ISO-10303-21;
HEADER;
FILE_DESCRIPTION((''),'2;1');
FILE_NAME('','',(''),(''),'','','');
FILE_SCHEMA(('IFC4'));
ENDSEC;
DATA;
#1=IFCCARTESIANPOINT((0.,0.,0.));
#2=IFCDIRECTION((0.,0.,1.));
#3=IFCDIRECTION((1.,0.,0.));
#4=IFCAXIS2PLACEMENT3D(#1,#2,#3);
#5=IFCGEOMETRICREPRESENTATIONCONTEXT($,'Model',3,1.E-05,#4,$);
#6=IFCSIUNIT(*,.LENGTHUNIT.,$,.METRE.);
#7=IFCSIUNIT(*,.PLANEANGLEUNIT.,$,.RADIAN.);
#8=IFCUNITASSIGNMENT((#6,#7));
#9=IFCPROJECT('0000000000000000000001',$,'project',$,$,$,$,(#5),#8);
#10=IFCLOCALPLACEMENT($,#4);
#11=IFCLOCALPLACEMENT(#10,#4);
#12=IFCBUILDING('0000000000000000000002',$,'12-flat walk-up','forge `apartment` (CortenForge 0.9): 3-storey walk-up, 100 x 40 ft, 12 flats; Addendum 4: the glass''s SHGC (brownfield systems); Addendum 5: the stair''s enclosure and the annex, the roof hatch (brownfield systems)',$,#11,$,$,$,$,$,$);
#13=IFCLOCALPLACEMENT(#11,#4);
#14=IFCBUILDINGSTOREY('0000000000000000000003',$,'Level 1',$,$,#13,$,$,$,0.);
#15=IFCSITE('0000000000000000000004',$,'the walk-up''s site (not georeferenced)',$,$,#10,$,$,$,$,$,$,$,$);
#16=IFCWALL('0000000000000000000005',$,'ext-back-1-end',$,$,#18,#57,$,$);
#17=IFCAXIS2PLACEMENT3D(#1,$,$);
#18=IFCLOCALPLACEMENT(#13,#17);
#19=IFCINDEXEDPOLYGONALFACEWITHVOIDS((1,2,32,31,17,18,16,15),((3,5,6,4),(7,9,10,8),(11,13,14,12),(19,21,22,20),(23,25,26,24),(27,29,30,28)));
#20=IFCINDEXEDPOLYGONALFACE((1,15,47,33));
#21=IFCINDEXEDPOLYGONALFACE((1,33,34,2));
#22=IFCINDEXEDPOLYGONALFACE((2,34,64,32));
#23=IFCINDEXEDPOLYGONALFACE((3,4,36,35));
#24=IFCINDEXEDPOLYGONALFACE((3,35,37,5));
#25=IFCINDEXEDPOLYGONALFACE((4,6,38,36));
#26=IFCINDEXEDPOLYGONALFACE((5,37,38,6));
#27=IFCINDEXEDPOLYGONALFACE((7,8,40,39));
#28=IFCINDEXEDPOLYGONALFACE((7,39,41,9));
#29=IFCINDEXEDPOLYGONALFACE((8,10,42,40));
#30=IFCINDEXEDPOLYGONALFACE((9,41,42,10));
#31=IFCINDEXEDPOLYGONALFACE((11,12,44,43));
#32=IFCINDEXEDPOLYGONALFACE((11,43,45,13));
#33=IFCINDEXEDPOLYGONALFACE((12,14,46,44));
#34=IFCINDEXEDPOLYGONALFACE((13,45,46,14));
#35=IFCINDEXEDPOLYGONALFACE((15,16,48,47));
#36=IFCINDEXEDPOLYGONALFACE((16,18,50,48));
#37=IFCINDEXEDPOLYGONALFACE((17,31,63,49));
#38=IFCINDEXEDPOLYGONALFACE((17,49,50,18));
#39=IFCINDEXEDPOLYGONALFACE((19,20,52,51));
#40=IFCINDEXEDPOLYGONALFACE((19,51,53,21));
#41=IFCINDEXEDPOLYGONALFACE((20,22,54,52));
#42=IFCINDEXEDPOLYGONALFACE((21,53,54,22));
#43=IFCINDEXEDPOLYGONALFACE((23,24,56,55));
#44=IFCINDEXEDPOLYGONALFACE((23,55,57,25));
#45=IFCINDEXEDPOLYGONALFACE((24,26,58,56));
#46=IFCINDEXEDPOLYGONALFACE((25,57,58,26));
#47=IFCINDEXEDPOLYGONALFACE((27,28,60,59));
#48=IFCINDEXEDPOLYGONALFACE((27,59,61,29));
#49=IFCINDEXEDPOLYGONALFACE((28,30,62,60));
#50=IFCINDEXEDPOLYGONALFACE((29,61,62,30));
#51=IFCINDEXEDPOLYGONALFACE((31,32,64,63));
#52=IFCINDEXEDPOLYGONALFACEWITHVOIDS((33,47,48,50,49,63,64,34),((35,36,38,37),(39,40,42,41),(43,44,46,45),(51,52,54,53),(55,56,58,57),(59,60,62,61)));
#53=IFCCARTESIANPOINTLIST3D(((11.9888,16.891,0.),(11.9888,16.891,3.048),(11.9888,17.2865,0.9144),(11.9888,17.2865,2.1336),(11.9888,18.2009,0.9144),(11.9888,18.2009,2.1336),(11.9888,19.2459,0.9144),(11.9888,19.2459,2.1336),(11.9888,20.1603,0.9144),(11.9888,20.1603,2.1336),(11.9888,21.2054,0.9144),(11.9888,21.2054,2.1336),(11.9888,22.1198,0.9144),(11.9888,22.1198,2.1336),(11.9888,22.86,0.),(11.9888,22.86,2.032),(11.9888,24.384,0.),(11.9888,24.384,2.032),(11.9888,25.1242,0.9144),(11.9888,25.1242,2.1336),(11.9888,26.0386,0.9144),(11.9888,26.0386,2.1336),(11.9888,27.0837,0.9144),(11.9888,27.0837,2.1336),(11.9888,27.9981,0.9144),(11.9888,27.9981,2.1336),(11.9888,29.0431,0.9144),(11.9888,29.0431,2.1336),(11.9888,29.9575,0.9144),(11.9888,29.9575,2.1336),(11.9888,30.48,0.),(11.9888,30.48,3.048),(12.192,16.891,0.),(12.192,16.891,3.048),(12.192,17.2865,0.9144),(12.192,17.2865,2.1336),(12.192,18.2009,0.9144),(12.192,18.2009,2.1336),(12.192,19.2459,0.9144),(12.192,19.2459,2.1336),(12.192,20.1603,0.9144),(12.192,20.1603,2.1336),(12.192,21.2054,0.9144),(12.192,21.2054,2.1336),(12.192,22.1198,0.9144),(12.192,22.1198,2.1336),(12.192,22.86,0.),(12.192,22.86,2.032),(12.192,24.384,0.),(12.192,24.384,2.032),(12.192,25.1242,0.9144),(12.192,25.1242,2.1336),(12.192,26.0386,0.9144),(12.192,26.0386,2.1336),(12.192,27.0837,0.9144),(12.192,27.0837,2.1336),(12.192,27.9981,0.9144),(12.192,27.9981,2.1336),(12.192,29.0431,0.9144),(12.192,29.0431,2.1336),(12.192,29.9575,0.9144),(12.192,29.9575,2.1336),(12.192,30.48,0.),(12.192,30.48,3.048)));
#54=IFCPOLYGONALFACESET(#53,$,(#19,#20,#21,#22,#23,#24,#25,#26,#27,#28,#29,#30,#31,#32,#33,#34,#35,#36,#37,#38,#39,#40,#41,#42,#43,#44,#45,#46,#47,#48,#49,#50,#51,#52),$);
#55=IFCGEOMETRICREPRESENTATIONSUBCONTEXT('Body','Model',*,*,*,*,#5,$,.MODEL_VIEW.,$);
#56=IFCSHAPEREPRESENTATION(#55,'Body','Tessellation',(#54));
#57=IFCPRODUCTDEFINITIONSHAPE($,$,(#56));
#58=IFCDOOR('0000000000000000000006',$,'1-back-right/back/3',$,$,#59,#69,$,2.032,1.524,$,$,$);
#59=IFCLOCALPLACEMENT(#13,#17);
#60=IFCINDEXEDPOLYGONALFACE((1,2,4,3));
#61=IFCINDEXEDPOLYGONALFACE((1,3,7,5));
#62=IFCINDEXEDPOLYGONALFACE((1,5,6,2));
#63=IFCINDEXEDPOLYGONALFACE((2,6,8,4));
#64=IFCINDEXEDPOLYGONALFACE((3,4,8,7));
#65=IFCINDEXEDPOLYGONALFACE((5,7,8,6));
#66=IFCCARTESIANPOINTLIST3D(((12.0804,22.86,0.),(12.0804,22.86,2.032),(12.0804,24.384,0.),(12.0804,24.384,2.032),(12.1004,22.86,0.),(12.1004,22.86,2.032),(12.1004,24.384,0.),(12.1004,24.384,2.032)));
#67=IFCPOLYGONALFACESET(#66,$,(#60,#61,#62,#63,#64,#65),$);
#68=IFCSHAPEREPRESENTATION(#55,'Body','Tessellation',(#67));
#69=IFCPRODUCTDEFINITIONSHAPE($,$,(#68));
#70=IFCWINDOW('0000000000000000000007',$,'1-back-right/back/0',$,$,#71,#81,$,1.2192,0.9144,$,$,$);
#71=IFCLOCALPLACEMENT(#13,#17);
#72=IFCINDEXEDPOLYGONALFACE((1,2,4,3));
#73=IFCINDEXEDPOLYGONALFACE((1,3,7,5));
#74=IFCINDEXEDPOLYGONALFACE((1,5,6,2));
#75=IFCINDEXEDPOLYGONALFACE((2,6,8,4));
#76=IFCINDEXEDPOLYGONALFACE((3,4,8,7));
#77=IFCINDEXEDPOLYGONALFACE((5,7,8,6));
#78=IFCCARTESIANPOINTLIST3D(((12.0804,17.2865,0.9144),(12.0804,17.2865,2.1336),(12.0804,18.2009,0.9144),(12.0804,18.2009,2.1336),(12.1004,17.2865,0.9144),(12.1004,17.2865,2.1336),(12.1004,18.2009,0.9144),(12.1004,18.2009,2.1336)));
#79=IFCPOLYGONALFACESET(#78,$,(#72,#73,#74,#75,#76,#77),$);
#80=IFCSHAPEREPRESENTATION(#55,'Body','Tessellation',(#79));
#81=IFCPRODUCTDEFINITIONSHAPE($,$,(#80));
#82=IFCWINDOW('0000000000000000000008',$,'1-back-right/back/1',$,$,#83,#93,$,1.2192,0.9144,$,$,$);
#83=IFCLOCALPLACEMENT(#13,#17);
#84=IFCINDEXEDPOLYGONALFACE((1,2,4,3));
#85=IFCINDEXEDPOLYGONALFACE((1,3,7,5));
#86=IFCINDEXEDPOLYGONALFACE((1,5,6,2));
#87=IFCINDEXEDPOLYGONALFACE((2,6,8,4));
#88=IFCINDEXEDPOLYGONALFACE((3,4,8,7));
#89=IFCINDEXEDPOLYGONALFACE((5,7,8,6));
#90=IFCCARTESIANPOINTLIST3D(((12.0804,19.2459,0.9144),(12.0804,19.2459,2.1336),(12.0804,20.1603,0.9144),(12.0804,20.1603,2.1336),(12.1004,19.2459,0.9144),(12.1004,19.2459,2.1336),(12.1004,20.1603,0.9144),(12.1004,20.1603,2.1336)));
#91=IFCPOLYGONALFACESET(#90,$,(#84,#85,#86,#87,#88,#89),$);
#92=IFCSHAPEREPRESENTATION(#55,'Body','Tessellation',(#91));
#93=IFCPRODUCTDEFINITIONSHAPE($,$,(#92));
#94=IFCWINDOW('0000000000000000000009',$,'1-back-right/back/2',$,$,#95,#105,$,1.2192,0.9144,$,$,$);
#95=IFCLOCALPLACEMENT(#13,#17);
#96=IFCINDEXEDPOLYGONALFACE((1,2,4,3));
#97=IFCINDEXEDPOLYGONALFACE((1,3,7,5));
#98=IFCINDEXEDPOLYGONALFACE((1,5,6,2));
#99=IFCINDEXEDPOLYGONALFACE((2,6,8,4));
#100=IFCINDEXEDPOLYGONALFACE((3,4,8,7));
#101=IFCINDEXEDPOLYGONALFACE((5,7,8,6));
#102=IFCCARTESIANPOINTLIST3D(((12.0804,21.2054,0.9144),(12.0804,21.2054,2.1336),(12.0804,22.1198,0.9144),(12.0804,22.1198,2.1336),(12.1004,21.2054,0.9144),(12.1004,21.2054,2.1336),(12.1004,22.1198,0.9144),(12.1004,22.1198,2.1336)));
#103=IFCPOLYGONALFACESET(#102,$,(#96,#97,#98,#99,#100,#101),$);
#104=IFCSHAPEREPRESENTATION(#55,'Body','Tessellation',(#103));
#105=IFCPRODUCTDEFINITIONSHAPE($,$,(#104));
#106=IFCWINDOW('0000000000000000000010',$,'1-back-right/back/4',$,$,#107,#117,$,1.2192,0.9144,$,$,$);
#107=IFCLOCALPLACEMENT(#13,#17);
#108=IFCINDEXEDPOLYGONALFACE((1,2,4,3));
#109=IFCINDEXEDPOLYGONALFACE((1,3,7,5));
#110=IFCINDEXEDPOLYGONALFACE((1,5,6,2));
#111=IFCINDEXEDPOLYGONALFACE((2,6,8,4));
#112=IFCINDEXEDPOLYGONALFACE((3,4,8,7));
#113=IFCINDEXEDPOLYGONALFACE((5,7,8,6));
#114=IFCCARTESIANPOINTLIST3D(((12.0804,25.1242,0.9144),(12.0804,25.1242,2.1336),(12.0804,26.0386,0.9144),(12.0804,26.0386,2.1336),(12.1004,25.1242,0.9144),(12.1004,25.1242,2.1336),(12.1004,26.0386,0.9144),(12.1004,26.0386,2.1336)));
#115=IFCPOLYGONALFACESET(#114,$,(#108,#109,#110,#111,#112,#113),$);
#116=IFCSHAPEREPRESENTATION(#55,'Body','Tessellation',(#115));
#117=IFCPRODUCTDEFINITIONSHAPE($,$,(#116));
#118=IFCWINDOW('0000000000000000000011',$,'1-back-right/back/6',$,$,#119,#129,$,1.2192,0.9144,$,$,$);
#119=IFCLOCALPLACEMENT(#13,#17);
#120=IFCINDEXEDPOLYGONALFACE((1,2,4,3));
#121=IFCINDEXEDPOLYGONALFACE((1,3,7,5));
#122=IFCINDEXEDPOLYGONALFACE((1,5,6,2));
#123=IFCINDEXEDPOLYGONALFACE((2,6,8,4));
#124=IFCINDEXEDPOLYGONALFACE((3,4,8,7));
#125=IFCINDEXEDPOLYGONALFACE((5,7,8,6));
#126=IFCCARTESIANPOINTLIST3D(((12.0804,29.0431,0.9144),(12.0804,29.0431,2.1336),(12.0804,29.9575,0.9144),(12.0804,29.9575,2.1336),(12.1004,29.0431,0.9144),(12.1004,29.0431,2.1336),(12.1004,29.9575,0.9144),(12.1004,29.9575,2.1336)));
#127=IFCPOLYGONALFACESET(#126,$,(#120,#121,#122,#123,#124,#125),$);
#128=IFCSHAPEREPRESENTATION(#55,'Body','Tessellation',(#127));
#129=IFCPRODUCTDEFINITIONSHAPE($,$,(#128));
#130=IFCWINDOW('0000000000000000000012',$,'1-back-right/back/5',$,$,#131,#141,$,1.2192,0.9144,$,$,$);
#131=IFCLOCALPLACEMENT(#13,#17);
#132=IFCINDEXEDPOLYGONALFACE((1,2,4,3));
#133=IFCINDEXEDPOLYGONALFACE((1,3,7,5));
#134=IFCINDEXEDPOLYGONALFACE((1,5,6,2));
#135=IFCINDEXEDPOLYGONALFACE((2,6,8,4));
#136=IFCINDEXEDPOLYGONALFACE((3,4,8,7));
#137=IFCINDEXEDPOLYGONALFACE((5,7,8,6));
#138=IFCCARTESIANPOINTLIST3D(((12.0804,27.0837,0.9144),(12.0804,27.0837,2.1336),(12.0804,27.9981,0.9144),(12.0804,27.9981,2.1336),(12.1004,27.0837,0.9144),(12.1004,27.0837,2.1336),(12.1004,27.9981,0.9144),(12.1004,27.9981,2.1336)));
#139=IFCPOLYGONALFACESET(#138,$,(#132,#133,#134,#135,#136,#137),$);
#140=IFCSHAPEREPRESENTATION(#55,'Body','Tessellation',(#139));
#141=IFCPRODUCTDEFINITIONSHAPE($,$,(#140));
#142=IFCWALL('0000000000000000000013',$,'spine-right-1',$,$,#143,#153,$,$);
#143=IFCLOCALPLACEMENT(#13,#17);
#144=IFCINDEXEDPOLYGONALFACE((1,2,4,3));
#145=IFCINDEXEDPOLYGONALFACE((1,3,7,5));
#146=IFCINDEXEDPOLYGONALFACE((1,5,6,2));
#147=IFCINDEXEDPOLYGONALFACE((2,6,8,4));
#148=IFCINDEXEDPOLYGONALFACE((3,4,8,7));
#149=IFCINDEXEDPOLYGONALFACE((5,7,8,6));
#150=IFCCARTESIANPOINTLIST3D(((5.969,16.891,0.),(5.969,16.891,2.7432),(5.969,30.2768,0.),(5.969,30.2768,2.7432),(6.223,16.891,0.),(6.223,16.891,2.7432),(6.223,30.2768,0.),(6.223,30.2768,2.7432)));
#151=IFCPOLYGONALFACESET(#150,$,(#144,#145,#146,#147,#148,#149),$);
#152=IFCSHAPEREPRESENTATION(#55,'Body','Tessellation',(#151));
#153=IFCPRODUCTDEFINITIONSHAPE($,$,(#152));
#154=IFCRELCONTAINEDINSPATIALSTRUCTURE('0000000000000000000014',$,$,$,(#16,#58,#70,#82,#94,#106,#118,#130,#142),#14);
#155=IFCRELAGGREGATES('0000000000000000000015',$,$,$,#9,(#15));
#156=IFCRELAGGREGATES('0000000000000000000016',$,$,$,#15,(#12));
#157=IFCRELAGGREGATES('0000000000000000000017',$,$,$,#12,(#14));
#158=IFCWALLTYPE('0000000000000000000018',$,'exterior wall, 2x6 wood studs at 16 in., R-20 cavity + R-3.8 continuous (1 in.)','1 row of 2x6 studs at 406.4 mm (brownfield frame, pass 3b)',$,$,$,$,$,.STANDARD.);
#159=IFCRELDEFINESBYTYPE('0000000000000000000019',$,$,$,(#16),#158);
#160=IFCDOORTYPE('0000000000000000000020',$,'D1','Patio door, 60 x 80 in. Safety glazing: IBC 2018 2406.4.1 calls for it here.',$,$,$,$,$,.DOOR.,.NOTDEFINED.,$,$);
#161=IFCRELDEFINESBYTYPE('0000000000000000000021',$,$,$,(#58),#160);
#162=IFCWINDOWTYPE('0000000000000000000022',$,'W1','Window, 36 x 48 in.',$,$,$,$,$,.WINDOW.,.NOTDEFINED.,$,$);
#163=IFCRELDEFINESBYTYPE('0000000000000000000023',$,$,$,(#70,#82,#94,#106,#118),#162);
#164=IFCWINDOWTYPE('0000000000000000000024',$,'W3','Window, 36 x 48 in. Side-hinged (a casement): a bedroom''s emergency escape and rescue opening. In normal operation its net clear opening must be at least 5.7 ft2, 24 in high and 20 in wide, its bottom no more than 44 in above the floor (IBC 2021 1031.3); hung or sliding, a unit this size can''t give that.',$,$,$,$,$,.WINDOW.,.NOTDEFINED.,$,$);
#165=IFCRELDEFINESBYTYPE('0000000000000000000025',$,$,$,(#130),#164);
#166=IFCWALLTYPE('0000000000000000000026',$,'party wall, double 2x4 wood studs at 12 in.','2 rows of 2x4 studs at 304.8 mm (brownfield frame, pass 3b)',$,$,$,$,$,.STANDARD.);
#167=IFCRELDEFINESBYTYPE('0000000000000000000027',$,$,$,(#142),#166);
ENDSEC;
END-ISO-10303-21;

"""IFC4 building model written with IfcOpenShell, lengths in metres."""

from ifc_helpers import new_model, si_unit, frame, frame_2d, origin, origin_with_axes, place, context, subcontext, project, spatial, rectangle, extrude, type_object, element, fill, save


model = new_model("IFC4")

# Units and contexts
model_context = context("Model", 3, precision=1e-05, world=origin_with_axes())
body_context = subcontext(model_context, "Body", "Model", "MODEL_VIEW")
ifc_project = project(units=[si_unit("LENGTHUNIT", "METRE"), si_unit("PLANEANGLEUNIT", "RADIAN")], contexts=[model_context])

# Site, building, storey
site_placement = place(None, origin_with_axes())
site = spatial("IfcSite", under=ifc_project, at=site_placement, Name="the walk-up's site (not georeferenced)")
building_placement = place(site_placement, origin_with_axes())
building = spatial("IfcBuilding", under=site, at=building_placement, Name="12-flat walk-up", Description="forge `apartment` (CortenForge 0.9): 3-storey walk-up, 100 x 40 ft, 12 flats; Addendum 4: the glass's SHGC (brownfield systems); Addendum 5: the stair's enclosure and the annex, the roof hatch (brownfield systems)")
storey_placement = place(building_placement, origin_with_axes())
storey = spatial("IfcBuildingStorey", under=building, at=storey_placement, Name="Level 1", Elevation=0.0)

# Wall, openings, door, windows
wall_type_1 = type_object("IfcWallType", Name="exterior wall, 2x6 wood studs at 16 in., R-20 cavity + R-3.8 continuous (1 in.)", Description="1 row of 2x6 studs at 406.4 mm (brownfield frame, pass 3b)", PredefinedType="STANDARD")
wall_1_placement = place(storey_placement, frame((11.9888, 16.891, 0.0), z_axis=(0.0, 0.0, 1.0), x_axis=(1.0, 0.0, 0.0)))
wall_1 = element("IfcWall", 1, at=wall_1_placement, inside=storey, type_object=wall_type_1, Name="ext-back-1-end", context=body_context, shape_type="SweptSolid", body=[
    extrude(rectangle(XDim=0.2032, YDim=13.589, at=frame_2d((0.1016, 6.7945))), origin(), (0.0, 0.0, 1.0), 3.048),
])
opening_1_placement = place(wall_1_placement, frame((0.2032, 0.3955, 0.9144), z_axis=(0.0, 0.0, 1.0), x_axis=(0.0, 1.0, 0.0)))
opening_1 = element("IfcOpeningElement", 2, at=opening_1_placement, cuts=wall_1, PredefinedType="OPENING", context=body_context, shape_type="SweptSolid", body=[
    extrude(rectangle(XDim=0.9144, YDim=0.2032, at=frame_2d((0.4572, 0.1016))), origin(), (0.0, 0.0, 1.0), 1.2192),
])
opening_2_placement = place(wall_1_placement, frame((0.2032, 2.3549, 0.9144), z_axis=(0.0, 0.0, 1.0), x_axis=(0.0, 1.0, 0.0)))
opening_2 = element("IfcOpeningElement", 3, at=opening_2_placement, cuts=wall_1, PredefinedType="OPENING", context=body_context, shape_type="SweptSolid", body=[
    extrude(rectangle(XDim=0.9144, YDim=0.2032, at=frame_2d((0.4572, 0.1016))), origin(), (0.0, 0.0, 1.0), 1.2192),
])
opening_3_placement = place(wall_1_placement, frame((0.2032, 4.3144, 0.9144), z_axis=(0.0, 0.0, 1.0), x_axis=(0.0, 1.0, 0.0)))
opening_3 = element("IfcOpeningElement", 4, at=opening_3_placement, cuts=wall_1, PredefinedType="OPENING", context=body_context, shape_type="SweptSolid", body=[
    extrude(rectangle(XDim=0.9144, YDim=0.2032, at=frame_2d((0.4572, 0.1016))), origin(), (0.0, 0.0, 1.0), 1.2192),
])
opening_4_placement = place(wall_1_placement, frame((0.2032, 5.969, 0.0), z_axis=(0.0, 0.0, 1.0), x_axis=(0.0, 1.0, 0.0)))
opening_4 = element("IfcOpeningElement", 5, at=opening_4_placement, cuts=wall_1, PredefinedType="OPENING", context=body_context, shape_type="SweptSolid", body=[
    extrude(rectangle(XDim=1.524, YDim=0.2032, at=frame_2d((0.762, 0.1016))), origin(), (0.0, 0.0, 1.0), 2.032),
])
opening_5_placement = place(wall_1_placement, frame((0.2032, 8.2332, 0.9144), z_axis=(0.0, 0.0, 1.0), x_axis=(0.0, 1.0, 0.0)))
opening_5 = element("IfcOpeningElement", 6, at=opening_5_placement, cuts=wall_1, PredefinedType="OPENING", context=body_context, shape_type="SweptSolid", body=[
    extrude(rectangle(XDim=0.9144, YDim=0.2032, at=frame_2d((0.4572, 0.1016))), origin(), (0.0, 0.0, 1.0), 1.2192),
])
opening_6_placement = place(wall_1_placement, frame((0.2032, 10.1927, 0.9144), z_axis=(0.0, 0.0, 1.0), x_axis=(0.0, 1.0, 0.0)))
opening_6 = element("IfcOpeningElement", 7, at=opening_6_placement, cuts=wall_1, PredefinedType="OPENING", context=body_context, shape_type="SweptSolid", body=[
    extrude(rectangle(XDim=0.9144, YDim=0.2032, at=frame_2d((0.4572, 0.1016))), origin(), (0.0, 0.0, 1.0), 1.2192),
])
opening_7_placement = place(wall_1_placement, frame((0.2032, 12.1521, 0.9144), z_axis=(0.0, 0.0, 1.0), x_axis=(0.0, 1.0, 0.0)))
opening_7 = element("IfcOpeningElement", 8, at=opening_7_placement, cuts=wall_1, PredefinedType="OPENING", context=body_context, shape_type="SweptSolid", body=[
    extrude(rectangle(XDim=0.9144, YDim=0.2032, at=frame_2d((0.4572, 0.1016))), origin(), (0.0, 0.0, 1.0), 1.2192),
])
door_type_1 = type_object("IfcDoorType", Name="D1", Description="Patio door, 60 x 80 in. Safety glazing: IBC 2018 2406.4.1 calls for it here.", OperationType="NOTDEFINED", PredefinedType="DOOR")
door_1_placement = place(opening_4_placement, frame((0.0, 0.0916, 0.0), z_axis=(0.0, 0.0, 1.0), x_axis=(1.0, 0.0, 0.0)))
door_1 = element("IfcDoor", 9, at=door_1_placement, inside=storey, type_object=door_type_1, Name="1-back-right/back/3", OverallHeight=2.032, OverallWidth=1.524, context=body_context, shape_type="SweptSolid", body=[
    extrude(rectangle(XDim=1.524, YDim=0.02, at=frame_2d((0.762, 0.01))), origin(), (0.0, 0.0, 1.0), 2.032),
])
fill(opening_4, door_1)
window_type_1 = type_object("IfcWindowType", Name="W1", Description="Window, 36 x 48 in.", PartitioningType="NOTDEFINED", PredefinedType="WINDOW")
window_1_placement = place(opening_1_placement, frame((0.0, 0.0916, 0.0), z_axis=(0.0, 0.0, 1.0), x_axis=(1.0, 0.0, 0.0)))
window_1 = element("IfcWindow", 10, at=window_1_placement, inside=storey, type_object=window_type_1, Name="1-back-right/back/0", OverallHeight=1.2192, OverallWidth=0.9144, context=body_context, shape_type="SweptSolid", body=[
    extrude(rectangle(XDim=0.9144, YDim=0.02, at=frame_2d((0.4572, 0.01))), origin(), (0.0, 0.0, 1.0), 1.2192),
])
fill(opening_1, window_1)
window_2_placement = place(opening_2_placement, frame((0.0, 0.0916, 0.0), z_axis=(0.0, 0.0, 1.0), x_axis=(1.0, 0.0, 0.0)))
window_2 = element("IfcWindow", 11, at=window_2_placement, inside=storey, type_object=window_type_1, Name="1-back-right/back/1", OverallHeight=1.2192, OverallWidth=0.9144, context=body_context, shape_type="SweptSolid", body=[
    extrude(rectangle(XDim=0.9144, YDim=0.02, at=frame_2d((0.4572, 0.01))), origin(), (0.0, 0.0, 1.0), 1.2192),
])
fill(opening_2, window_2)
window_3_placement = place(opening_3_placement, frame((0.0, 0.0916, 0.0), z_axis=(0.0, 0.0, 1.0), x_axis=(1.0, 0.0, 0.0)))
window_3 = element("IfcWindow", 12, at=window_3_placement, inside=storey, type_object=window_type_1, Name="1-back-right/back/2", OverallHeight=1.2192, OverallWidth=0.9144, context=body_context, shape_type="SweptSolid", body=[
    extrude(rectangle(XDim=0.9144, YDim=0.02, at=frame_2d((0.4572, 0.01))), origin(), (0.0, 0.0, 1.0), 1.2192),
])
fill(opening_3, window_3)
window_4_placement = place(opening_5_placement, frame((0.0, 0.0916, 0.0), z_axis=(0.0, 0.0, 1.0), x_axis=(1.0, 0.0, 0.0)))
window_4 = element("IfcWindow", 13, at=window_4_placement, inside=storey, type_object=window_type_1, Name="1-back-right/back/4", OverallHeight=1.2192, OverallWidth=0.9144, context=body_context, shape_type="SweptSolid", body=[
    extrude(rectangle(XDim=0.9144, YDim=0.02, at=frame_2d((0.4572, 0.01))), origin(), (0.0, 0.0, 1.0), 1.2192),
])
fill(opening_5, window_4)
window_5_placement = place(opening_7_placement, frame((0.0, 0.0916, 0.0), z_axis=(0.0, 0.0, 1.0), x_axis=(1.0, 0.0, 0.0)))
window_5 = element("IfcWindow", 14, at=window_5_placement, inside=storey, type_object=window_type_1, Name="1-back-right/back/6", OverallHeight=1.2192, OverallWidth=0.9144, context=body_context, shape_type="SweptSolid", body=[
    extrude(rectangle(XDim=0.9144, YDim=0.02, at=frame_2d((0.4572, 0.01))), origin(), (0.0, 0.0, 1.0), 1.2192),
])
fill(opening_7, window_5)
window_type_2 = type_object("IfcWindowType", Name="W3", Description="Window, 36 x 48 in. Side-hinged (a casement): a bedroom's emergency escape and rescue opening. In normal operation its net clear opening must be at least 5.7 ft2, 24 in high and 20 in wide, its bottom no more than 44 in above the floor (IBC 2021 1031.3); hung or sliding, a unit this size can't give that.", PartitioningType="NOTDEFINED", PredefinedType="WINDOW")
window_6_placement = place(opening_6_placement, frame((0.0, 0.0916, 0.0), z_axis=(0.0, 0.0, 1.0), x_axis=(1.0, 0.0, 0.0)))
window_6 = element("IfcWindow", 15, at=window_6_placement, inside=storey, type_object=window_type_2, Name="1-back-right/back/5", OverallHeight=1.2192, OverallWidth=0.9144, context=body_context, shape_type="SweptSolid", body=[
    extrude(rectangle(XDim=0.9144, YDim=0.02, at=frame_2d((0.4572, 0.01))), origin(), (0.0, 0.0, 1.0), 1.2192),
])
fill(opening_6, window_6)

# Wall
wall_type_2 = type_object("IfcWallType", Name="party wall, double 2x4 wood studs at 12 in.", Description="2 rows of 2x4 studs at 304.8 mm (brownfield frame, pass 3b)", PredefinedType="STANDARD")
wall_2_placement = place(storey_placement, frame((5.969, 16.891, 0.0), z_axis=(0.0, 0.0, 1.0), x_axis=(1.0, 0.0, 0.0)))
element("IfcWall", 16, at=wall_2_placement, inside=storey, type_object=wall_type_2, Name="spine-right-1", context=body_context, shape_type="SweptSolid", body=[
    extrude(rectangle(XDim=0.254, YDim=13.3858, at=frame_2d((0.127, 6.6929))), origin(), (0.0, 0.0, 1.0), 2.7432),
])

save(model, "model.ifc")
